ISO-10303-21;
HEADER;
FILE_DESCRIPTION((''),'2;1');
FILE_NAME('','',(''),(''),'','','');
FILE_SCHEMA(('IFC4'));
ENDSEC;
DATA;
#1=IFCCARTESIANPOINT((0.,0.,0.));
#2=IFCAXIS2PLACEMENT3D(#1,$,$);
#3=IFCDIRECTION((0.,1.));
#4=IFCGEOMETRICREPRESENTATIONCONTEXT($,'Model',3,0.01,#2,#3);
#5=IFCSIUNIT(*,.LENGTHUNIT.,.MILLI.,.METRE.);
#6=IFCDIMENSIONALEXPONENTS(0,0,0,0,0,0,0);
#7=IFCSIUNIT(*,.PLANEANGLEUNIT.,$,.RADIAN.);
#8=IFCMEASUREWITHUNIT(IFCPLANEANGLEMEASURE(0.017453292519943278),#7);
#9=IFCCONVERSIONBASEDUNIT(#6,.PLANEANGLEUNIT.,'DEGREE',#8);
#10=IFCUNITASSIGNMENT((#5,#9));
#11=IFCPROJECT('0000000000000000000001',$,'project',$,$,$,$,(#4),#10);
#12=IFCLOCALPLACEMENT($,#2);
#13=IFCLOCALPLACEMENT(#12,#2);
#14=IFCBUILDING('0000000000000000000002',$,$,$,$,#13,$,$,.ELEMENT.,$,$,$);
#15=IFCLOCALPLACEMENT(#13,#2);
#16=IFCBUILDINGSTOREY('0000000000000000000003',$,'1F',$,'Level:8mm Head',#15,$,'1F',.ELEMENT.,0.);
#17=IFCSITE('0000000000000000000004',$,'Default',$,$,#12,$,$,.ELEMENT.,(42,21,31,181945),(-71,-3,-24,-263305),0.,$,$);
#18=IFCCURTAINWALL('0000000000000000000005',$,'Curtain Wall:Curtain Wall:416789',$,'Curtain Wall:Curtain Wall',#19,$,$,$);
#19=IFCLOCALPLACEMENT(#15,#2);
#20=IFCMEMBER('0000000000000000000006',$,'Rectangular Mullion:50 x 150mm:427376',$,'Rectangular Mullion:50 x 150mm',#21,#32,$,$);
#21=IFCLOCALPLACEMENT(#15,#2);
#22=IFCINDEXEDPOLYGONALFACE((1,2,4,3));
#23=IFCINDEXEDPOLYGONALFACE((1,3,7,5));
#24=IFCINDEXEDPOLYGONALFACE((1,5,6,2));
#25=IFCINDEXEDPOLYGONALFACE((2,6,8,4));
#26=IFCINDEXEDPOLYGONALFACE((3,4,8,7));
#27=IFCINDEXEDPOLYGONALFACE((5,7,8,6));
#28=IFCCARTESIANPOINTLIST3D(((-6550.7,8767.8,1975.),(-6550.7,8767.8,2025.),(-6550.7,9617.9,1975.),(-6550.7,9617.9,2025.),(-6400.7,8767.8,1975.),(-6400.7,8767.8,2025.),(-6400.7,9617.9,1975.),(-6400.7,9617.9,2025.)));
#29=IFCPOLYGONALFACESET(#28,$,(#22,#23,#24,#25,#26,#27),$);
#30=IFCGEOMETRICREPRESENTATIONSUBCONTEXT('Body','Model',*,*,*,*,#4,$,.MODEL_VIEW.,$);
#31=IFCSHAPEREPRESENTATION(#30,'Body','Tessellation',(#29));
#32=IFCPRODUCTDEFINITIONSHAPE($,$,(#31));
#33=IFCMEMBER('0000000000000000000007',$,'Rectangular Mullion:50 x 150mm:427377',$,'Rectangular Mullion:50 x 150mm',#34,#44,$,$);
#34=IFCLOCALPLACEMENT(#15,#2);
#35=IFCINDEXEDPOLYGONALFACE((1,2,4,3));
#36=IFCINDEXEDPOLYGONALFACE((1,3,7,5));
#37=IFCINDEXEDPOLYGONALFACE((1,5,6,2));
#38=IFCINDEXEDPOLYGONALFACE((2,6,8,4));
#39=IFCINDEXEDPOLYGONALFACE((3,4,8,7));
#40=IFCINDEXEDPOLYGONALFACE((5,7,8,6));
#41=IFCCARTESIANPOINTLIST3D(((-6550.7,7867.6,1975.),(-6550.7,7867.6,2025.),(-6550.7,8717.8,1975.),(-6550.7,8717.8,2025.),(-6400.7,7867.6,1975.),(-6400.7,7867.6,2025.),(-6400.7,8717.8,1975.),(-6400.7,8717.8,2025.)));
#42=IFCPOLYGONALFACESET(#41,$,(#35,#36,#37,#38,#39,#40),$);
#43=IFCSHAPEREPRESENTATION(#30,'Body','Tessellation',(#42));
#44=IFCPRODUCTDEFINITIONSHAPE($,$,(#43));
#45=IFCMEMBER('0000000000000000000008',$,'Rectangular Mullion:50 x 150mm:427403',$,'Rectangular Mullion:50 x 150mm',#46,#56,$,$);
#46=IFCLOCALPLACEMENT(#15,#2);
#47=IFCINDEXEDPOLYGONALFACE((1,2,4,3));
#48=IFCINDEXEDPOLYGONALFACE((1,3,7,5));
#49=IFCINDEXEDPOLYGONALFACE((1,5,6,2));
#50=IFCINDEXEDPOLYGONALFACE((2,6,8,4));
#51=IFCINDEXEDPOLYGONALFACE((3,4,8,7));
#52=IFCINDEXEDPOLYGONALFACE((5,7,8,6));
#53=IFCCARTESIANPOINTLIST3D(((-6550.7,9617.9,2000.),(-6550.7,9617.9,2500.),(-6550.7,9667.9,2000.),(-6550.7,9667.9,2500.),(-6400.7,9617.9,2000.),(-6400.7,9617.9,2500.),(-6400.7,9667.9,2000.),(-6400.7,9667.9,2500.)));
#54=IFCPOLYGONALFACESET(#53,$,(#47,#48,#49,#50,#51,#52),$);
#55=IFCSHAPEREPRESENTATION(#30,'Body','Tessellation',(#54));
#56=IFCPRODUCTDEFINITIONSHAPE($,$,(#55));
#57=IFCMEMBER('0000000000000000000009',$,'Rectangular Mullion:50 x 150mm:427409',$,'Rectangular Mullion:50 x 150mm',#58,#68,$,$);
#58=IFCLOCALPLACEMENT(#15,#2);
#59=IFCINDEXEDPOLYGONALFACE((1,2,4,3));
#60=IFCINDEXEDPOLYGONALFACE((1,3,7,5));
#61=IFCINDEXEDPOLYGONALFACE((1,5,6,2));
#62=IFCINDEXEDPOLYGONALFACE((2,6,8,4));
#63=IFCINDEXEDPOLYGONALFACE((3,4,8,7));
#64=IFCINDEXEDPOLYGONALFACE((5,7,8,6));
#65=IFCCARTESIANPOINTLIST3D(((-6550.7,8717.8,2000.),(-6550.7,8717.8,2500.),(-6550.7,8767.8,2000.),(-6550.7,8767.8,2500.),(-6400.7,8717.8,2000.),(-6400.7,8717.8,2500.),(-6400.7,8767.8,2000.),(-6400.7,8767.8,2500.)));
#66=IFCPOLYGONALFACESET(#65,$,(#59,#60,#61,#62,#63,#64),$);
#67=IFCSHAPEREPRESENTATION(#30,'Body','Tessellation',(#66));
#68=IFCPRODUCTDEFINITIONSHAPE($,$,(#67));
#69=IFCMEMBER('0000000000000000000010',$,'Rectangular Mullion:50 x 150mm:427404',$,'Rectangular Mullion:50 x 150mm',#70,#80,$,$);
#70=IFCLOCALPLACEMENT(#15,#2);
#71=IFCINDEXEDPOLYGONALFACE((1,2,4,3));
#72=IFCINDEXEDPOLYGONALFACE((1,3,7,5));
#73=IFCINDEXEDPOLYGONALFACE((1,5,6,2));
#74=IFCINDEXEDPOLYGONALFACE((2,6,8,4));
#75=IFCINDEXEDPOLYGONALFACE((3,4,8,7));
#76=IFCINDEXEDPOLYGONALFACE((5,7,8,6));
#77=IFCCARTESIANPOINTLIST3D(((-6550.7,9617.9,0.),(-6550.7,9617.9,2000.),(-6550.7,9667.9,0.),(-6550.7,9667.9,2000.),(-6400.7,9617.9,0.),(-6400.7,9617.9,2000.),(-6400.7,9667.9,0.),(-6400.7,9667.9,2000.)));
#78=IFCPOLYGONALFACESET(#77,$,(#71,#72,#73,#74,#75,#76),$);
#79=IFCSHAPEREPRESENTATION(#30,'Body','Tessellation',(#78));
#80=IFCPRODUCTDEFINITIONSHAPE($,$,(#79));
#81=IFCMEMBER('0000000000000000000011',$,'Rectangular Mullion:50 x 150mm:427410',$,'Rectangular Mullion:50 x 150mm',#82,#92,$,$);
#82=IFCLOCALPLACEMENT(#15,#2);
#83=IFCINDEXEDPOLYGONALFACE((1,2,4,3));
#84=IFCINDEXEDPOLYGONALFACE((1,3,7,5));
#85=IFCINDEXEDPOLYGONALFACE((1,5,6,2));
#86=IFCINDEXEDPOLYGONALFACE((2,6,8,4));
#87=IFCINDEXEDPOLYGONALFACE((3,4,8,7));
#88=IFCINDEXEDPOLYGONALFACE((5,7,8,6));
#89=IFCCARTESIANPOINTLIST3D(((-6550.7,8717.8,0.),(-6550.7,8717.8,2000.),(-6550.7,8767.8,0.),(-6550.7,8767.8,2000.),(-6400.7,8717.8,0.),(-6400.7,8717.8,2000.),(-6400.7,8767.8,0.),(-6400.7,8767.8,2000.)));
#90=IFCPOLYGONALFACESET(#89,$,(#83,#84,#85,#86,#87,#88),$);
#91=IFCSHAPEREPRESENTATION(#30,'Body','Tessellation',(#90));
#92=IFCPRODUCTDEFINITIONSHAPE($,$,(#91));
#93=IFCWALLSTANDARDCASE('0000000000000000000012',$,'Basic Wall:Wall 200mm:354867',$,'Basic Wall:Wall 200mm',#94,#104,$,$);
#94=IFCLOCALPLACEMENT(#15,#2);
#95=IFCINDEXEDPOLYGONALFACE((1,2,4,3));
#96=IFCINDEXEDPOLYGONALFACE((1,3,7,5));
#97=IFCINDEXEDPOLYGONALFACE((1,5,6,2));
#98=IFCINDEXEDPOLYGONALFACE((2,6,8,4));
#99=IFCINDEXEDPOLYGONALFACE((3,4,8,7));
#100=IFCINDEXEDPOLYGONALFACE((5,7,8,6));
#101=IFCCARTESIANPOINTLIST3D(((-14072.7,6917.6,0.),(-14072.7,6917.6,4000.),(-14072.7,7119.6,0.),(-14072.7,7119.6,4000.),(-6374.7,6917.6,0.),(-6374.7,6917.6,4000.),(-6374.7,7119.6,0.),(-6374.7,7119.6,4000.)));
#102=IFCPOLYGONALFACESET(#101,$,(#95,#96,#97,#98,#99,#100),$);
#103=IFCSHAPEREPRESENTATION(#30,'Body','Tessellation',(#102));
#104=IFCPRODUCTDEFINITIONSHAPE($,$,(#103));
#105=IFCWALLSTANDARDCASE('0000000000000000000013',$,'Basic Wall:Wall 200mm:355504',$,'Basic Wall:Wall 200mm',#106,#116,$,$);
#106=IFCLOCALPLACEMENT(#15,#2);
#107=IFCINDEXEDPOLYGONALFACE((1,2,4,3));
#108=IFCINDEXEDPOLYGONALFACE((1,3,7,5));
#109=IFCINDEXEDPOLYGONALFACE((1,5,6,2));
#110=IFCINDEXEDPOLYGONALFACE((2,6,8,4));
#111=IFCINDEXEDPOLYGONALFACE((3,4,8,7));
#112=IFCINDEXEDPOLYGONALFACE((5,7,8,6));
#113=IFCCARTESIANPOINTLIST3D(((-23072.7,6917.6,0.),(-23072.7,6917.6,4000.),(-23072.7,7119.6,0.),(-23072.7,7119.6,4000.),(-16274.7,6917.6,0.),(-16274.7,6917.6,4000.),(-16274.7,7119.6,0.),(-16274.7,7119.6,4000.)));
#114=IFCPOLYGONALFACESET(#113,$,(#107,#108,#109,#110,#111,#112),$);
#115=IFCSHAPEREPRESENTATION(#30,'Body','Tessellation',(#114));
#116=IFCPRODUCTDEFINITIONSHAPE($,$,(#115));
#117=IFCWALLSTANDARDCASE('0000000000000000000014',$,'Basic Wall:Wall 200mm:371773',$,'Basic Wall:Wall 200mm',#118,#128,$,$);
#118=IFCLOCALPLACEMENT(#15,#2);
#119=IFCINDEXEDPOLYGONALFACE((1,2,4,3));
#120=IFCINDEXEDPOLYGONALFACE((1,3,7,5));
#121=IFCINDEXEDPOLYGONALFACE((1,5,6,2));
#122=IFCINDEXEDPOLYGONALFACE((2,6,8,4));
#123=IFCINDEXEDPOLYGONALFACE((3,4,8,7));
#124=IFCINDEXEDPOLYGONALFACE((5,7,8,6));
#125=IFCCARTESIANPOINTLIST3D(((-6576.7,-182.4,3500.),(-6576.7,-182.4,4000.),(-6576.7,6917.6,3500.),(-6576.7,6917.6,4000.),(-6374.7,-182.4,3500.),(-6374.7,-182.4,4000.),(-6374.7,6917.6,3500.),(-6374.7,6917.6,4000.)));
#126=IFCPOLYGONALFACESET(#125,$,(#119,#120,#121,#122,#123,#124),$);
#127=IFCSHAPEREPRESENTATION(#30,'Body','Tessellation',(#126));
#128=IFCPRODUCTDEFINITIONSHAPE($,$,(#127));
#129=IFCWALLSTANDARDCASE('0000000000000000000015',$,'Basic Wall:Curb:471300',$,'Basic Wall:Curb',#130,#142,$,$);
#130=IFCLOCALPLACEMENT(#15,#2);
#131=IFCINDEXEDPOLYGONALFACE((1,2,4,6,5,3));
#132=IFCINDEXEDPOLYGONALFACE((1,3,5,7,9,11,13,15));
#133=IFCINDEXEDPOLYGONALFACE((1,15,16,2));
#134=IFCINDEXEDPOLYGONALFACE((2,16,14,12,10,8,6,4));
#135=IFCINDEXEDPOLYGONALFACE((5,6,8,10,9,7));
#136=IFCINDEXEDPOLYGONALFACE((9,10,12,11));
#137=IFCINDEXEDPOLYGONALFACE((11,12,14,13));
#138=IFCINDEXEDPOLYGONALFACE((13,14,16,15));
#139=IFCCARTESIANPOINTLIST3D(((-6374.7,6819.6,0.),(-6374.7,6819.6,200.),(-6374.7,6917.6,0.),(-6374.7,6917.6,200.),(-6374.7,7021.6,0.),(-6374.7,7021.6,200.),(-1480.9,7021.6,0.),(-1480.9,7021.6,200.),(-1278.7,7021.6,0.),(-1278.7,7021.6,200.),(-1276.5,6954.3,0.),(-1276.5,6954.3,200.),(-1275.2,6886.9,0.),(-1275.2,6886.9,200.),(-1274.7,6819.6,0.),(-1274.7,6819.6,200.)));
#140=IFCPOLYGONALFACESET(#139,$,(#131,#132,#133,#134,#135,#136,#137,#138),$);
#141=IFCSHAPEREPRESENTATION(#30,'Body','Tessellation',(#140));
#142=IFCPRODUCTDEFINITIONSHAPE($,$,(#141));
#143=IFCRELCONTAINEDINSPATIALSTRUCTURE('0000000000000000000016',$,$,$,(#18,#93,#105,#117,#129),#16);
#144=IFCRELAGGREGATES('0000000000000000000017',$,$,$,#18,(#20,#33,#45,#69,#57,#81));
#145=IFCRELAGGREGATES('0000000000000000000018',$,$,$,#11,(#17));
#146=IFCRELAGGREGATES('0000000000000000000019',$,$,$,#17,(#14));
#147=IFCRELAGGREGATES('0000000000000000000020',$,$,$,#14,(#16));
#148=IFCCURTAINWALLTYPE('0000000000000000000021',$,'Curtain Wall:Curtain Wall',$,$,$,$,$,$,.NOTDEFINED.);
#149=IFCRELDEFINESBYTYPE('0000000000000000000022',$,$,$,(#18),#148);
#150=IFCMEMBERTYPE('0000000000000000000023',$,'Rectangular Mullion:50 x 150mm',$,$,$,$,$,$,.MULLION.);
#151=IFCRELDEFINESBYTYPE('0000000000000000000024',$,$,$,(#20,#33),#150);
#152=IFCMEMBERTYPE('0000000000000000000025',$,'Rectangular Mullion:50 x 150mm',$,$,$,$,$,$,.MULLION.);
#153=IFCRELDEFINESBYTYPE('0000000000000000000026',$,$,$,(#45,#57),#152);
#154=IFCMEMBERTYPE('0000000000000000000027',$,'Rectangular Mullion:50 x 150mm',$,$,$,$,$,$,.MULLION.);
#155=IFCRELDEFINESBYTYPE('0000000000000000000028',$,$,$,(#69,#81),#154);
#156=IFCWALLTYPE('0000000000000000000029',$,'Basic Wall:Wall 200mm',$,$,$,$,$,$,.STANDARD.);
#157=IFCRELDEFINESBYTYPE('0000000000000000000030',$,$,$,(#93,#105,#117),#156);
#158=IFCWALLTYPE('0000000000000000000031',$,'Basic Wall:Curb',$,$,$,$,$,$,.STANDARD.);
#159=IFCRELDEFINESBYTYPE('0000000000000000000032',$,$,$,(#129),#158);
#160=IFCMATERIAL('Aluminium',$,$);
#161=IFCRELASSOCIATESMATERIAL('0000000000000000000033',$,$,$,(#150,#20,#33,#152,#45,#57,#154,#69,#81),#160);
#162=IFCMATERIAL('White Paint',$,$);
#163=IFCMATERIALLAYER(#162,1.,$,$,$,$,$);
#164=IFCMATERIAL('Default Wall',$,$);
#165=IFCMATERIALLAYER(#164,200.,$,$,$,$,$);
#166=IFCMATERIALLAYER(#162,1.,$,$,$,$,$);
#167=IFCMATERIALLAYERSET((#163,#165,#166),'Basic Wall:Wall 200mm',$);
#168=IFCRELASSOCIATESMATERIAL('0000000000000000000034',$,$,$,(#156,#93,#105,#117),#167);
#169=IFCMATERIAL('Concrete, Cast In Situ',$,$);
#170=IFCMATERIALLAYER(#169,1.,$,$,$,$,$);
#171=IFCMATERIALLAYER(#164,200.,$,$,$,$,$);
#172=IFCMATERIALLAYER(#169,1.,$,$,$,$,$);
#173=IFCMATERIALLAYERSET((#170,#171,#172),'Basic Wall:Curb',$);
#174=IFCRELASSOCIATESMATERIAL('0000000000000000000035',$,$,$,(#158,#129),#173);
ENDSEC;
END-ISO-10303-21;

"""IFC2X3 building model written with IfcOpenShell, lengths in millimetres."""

from ifc_helpers import new_model, entity, si_unit, converted_unit, direction, frame, frame_2d, origin, origin_2d_with_axis, place, context, subcontext, project, spatial, polyline, circle_curve, parameter, trimmed, segment, composite_curve, rectangle, outline, extrude, source, transform, mapped, material, layer, layer_set, layer_usage, type_object, type_shapes, element, aggregate, save


model = new_model("IFC2X3")

# Units and contexts
model_context = context("Model", 3, precision=0.01, world=origin(), true_north=direction((0.0, 1.0)))
body_context = subcontext(model_context, "Body", "Model", "MODEL_VIEW")
ifc_project = project(units=[si_unit("LENGTHUNIT", "METRE", prefix="MILLI"), converted_unit("PLANEANGLEUNIT", "DEGREE", entity("IfcPlaneAngleMeasure", 0.017453292519943278), si_unit("PLANEANGLEUNIT", "RADIAN"), dimensions=[0, 0, 0, 0, 0, 0, 0])], contexts=[model_context])

# Site, building, storey
site_placement = place(None, origin())
site = spatial("IfcSite", under=ifc_project, at=site_placement, Name="Default", CompositionType="ELEMENT", RefLatitude=(42, 21, 31, 181945), RefLongitude=(-71, -3, -24, -263305), RefElevation=0.0)
building_placement = place(site_placement, origin())
building = spatial("IfcBuilding", under=site, at=building_placement, CompositionType="ELEMENT")
storey_placement = place(building_placement, origin())
storey = spatial("IfcBuildingStorey", under=building, at=storey_placement, Name="1F", ObjectType="Level:8mm Head", LongName="1F", CompositionType="ELEMENT", Elevation=0.0)

# Shared definitions
ifc_material_1 = material(Name="White Paint")

# Curtain wall, members
curtain_wall_type = type_object("IfcCurtainWallType", Name="Curtain Wall:Curtain Wall", PredefinedType="NOTDEFINED")
curtain_wall_placement = place(storey_placement, origin())
curtain_wall = element("IfcCurtainWall", 1, at=curtain_wall_placement, inside=storey, type_object=curtain_wall_type, Name="Curtain Wall:Curtain Wall:416789", ObjectType="Curtain Wall:Curtain Wall")
ifc_material_2 = material(Name="Aluminium")
member_type_1 = type_object("IfcMemberType", Name="Rectangular Mullion:50 x 150mm", PredefinedType="MULLION", material=ifc_material_2)
shared_shape_1 = source(origin(), body_context, "Body", "SweptSolid", [
    extrude(rectangle(XDim=50.0, YDim=150.0, at=origin_2d_with_axis()), frame((0.0, 0.0, -850.2), z_axis=(0.0, 0.0, 1.0), x_axis=(-1.0, 0.0, 0.0)), (0.0, 0.0, 1.0), 850.2),
])
type_shapes(member_type_1, [shared_shape_1])
member_1_placement = place(curtain_wall_placement, frame((-6475.7, 8767.8, 2000.0), z_axis=(0.0, -1.0, 0.0), x_axis=(0.0, 0.0, 1.0)))
member_1 = element("IfcMember", 2, at=member_1_placement, type_object=member_type_1, material=ifc_material_2, Name="Rectangular Mullion:50 x 150mm:427376", ObjectType="Rectangular Mullion:50 x 150mm", context=body_context, shape_type="MappedRepresentation", body=[
    mapped(shared_shape_1, transform((0.0, 0.0, 0.0), scale=1.0)),
])
member_2_placement = place(curtain_wall_placement, frame((-6475.7, 7867.6, 2000.0), z_axis=(0.0, -1.0, 0.0), x_axis=(0.0, 0.0, 1.0)))
member_2 = element("IfcMember", 3, at=member_2_placement, type_object=member_type_1, material=ifc_material_2, Name="Rectangular Mullion:50 x 150mm:427377", ObjectType="Rectangular Mullion:50 x 150mm", context=body_context, shape_type="MappedRepresentation", body=[
    mapped(shared_shape_1, transform((0.0, 0.0, 0.0), scale=1.0)),
])
member_type_2 = type_object("IfcMemberType", Name="Rectangular Mullion:50 x 150mm", PredefinedType="MULLION", material=ifc_material_2)
shared_shape_2 = source(origin(), body_context, "Body", "SweptSolid", [
    extrude(rectangle(XDim=50.0, YDim=150.0, at=origin_2d_with_axis()), frame((0.0, 0.0, -500.0), z_axis=(0.0, 0.0, 1.0), x_axis=(-1.0, 0.0, 0.0)), (0.0, 0.0, 1.0), 500.0),
])
type_shapes(member_type_2, [shared_shape_2])
member_3_placement = place(curtain_wall_placement, frame((-6475.7, 9642.9, 2000.0), z_axis=(0.0, 0.0, -1.0), x_axis=(0.0, -1.0, 0.0)))
member_3 = element("IfcMember", 4, at=member_3_placement, type_object=member_type_2, material=ifc_material_2, Name="Rectangular Mullion:50 x 150mm:427403", ObjectType="Rectangular Mullion:50 x 150mm", context=body_context, shape_type="MappedRepresentation", body=[
    mapped(shared_shape_2, transform((0.0, 0.0, 0.0), scale=1.0)),
])
member_4_placement = place(curtain_wall_placement, frame((-6475.7, 8742.8, 2000.0), z_axis=(0.0, 0.0, -1.0), x_axis=(0.0, -1.0, 0.0)))
member_4 = element("IfcMember", 5, at=member_4_placement, type_object=member_type_2, material=ifc_material_2, Name="Rectangular Mullion:50 x 150mm:427409", ObjectType="Rectangular Mullion:50 x 150mm", context=body_context, shape_type="MappedRepresentation", body=[
    mapped(shared_shape_2, transform((0.0, 0.0, 0.0), scale=1.0)),
])
member_type_3 = type_object("IfcMemberType", Name="Rectangular Mullion:50 x 150mm", PredefinedType="MULLION", material=ifc_material_2)
shared_shape_3 = source(origin(), body_context, "Body", "SweptSolid", [
    extrude(rectangle(XDim=50.0, YDim=150.0, at=origin_2d_with_axis()), frame((0.0, 0.0, -2000.0), z_axis=(0.0, 0.0, 1.0), x_axis=(-1.0, 0.0, 0.0)), (0.0, 0.0, 1.0), 2000.0),
])
type_shapes(member_type_3, [shared_shape_3])
member_5_placement = place(curtain_wall_placement, frame((-6475.7, 9642.9, 0.0), z_axis=(0.0, 0.0, -1.0), x_axis=(0.0, -1.0, 0.0)))
member_5 = element("IfcMember", 6, at=member_5_placement, type_object=member_type_3, material=ifc_material_2, Name="Rectangular Mullion:50 x 150mm:427404", ObjectType="Rectangular Mullion:50 x 150mm", context=body_context, shape_type="MappedRepresentation", body=[
    mapped(shared_shape_3, transform((0.0, 0.0, 0.0), scale=1.0)),
])
member_6_placement = place(curtain_wall_placement, frame((-6475.7, 8742.8, 0.0), z_axis=(0.0, 0.0, -1.0), x_axis=(0.0, -1.0, 0.0)))
member_6 = element("IfcMember", 7, at=member_6_placement, type_object=member_type_3, material=ifc_material_2, Name="Rectangular Mullion:50 x 150mm:427410", ObjectType="Rectangular Mullion:50 x 150mm", context=body_context, shape_type="MappedRepresentation", body=[
    mapped(shared_shape_3, transform((0.0, 0.0, 0.0), scale=1.0)),
])
aggregate(curtain_wall, [member_1, member_2, member_3, member_5, member_4, member_6])

# Walls
ifc_layer_1 = layer(ifc_material_1, 1.0)
ifc_material_3 = material(Name="Default Wall")
ifc_layer_2 = layer(ifc_material_3, 200.0)
ifc_layer_3 = layer(ifc_material_1, 1.0)
ifc_layer_set_1 = layer_set([ifc_layer_1, ifc_layer_2, ifc_layer_3], Name="Basic Wall:Wall 200mm")
ifc_layer_usage_1 = layer_usage(ifc_layer_set_1, "AXIS2", "NEGATIVE", 101.0)
wall_type_1 = type_object("IfcWallType", Name="Basic Wall:Wall 200mm", PredefinedType="STANDARD", material=ifc_layer_set_1)
wall_1_placement = place(storey_placement, frame((-6374.7, 7018.6, 0.0), z_axis=(0.0, 0.0, 1.0), x_axis=(-1.0, 0.0, 0.0)))
element("IfcWallStandardCase", 8, at=wall_1_placement, inside=storey, type_object=wall_type_1, material=ifc_layer_usage_1, Name="Basic Wall:Wall 200mm:354867", ObjectType="Basic Wall:Wall 200mm", context=body_context, shape_type="SweptSolid", body=[
    extrude(rectangle(XDim=7698.0, YDim=202.0, at=frame_2d((3849.0, 0.0), x_axis=(-1.0, 0.0))), origin(), (0.0, 0.0, 1.0), 4000.0),
])
ifc_layer_usage_2 = layer_usage(ifc_layer_set_1, "AXIS2", "NEGATIVE", 101.0)
wall_2_placement = place(storey_placement, frame((-23072.7, 7018.6, 0.0)))
element("IfcWallStandardCase", 9, at=wall_2_placement, inside=storey, type_object=wall_type_1, material=ifc_layer_usage_2, Name="Basic Wall:Wall 200mm:355504", ObjectType="Basic Wall:Wall 200mm", context=body_context, shape_type="SweptSolid", body=[
    extrude(rectangle(XDim=6798.0, YDim=202.0, at=frame_2d((3399.0, 0.0), x_axis=(-1.0, 0.0))), origin(), (0.0, 0.0, 1.0), 4000.0),
])
ifc_layer_usage_3 = layer_usage(ifc_layer_set_1, "AXIS2", "NEGATIVE", 101.0)
wall_3_placement = place(storey_placement, frame((-6475.7, 6917.6, 3500.0), z_axis=(0.0, 0.0, 1.0), x_axis=(0.0, -1.0, 0.0)))
element("IfcWallStandardCase", 10, at=wall_3_placement, inside=storey, type_object=wall_type_1, material=ifc_layer_usage_3, Name="Basic Wall:Wall 200mm:371773", ObjectType="Basic Wall:Wall 200mm", context=body_context, shape_type="SweptSolid", body=[
    extrude(rectangle(XDim=7100.0, YDim=202.0, at=frame_2d((3550.0, 0.0), x_axis=(-1.0, 0.0))), origin(), (0.0, 0.0, 1.0), 500.0),
])
ifc_material_4 = material(Name="Concrete, Cast In Situ")
ifc_layer_4 = layer(ifc_material_4, 1.0)
ifc_layer_5 = layer(ifc_material_3, 200.0)
ifc_layer_6 = layer(ifc_material_4, 1.0)
ifc_layer_set_2 = layer_set([ifc_layer_4, ifc_layer_5, ifc_layer_6], Name="Basic Wall:Curb")
ifc_layer_usage_4 = layer_usage(ifc_layer_set_2, "AXIS2", "NEGATIVE", 101.0)
wall_type_2 = type_object("IfcWallType", Name="Basic Wall:Curb", PredefinedType="STANDARD", material=ifc_layer_set_2)
wall_4_placement = place(storey_placement, frame((-1274.7, 6920.6, 0.0), z_axis=(0.0, 0.0, 1.0), x_axis=(-1.0, 0.0, 0.0)))
element("IfcWallStandardCase", 11, at=wall_4_placement, inside=storey, type_object=wall_type_2, material=ifc_layer_usage_4, Name="Basic Wall:Curb:471300", ObjectType="Basic Wall:Curb", context=body_context, shape_type="SweptSolid", body=[
    extrude(outline(composite_curve([segment(polyline([(5100.0, -101.0), (5100.0, 3.0)]), True, "CONTINUOUS"), segment(polyline([(5100.0, 3.0), (5100.0, 101.0)]), True, "CONTINUOUS"), segment(polyline([(5100.0, 101.0), (0.0, 101.0)]), True, "CONTINUOUS"), segment(trimmed(circle_curve(frame_2d((5100.0, 101.0), x_axis=(-1.0, 0.0)), 5100.0), [parameter(0.0)], [parameter(2.269956)], True, "PARAMETER"), True, "CONTINUOUS"), segment(polyline([(4.0, -101.0), (206.2, -101.0)]), True, "CONTINUOUS"), segment(polyline([(206.2, -101.0), (5100.0, -101.0)]), True, "CONTINUOUS")], self_intersect=False)), origin(), (0.0, 0.0, 1.0), 200.0),
])

save(model, "model.ifc")
